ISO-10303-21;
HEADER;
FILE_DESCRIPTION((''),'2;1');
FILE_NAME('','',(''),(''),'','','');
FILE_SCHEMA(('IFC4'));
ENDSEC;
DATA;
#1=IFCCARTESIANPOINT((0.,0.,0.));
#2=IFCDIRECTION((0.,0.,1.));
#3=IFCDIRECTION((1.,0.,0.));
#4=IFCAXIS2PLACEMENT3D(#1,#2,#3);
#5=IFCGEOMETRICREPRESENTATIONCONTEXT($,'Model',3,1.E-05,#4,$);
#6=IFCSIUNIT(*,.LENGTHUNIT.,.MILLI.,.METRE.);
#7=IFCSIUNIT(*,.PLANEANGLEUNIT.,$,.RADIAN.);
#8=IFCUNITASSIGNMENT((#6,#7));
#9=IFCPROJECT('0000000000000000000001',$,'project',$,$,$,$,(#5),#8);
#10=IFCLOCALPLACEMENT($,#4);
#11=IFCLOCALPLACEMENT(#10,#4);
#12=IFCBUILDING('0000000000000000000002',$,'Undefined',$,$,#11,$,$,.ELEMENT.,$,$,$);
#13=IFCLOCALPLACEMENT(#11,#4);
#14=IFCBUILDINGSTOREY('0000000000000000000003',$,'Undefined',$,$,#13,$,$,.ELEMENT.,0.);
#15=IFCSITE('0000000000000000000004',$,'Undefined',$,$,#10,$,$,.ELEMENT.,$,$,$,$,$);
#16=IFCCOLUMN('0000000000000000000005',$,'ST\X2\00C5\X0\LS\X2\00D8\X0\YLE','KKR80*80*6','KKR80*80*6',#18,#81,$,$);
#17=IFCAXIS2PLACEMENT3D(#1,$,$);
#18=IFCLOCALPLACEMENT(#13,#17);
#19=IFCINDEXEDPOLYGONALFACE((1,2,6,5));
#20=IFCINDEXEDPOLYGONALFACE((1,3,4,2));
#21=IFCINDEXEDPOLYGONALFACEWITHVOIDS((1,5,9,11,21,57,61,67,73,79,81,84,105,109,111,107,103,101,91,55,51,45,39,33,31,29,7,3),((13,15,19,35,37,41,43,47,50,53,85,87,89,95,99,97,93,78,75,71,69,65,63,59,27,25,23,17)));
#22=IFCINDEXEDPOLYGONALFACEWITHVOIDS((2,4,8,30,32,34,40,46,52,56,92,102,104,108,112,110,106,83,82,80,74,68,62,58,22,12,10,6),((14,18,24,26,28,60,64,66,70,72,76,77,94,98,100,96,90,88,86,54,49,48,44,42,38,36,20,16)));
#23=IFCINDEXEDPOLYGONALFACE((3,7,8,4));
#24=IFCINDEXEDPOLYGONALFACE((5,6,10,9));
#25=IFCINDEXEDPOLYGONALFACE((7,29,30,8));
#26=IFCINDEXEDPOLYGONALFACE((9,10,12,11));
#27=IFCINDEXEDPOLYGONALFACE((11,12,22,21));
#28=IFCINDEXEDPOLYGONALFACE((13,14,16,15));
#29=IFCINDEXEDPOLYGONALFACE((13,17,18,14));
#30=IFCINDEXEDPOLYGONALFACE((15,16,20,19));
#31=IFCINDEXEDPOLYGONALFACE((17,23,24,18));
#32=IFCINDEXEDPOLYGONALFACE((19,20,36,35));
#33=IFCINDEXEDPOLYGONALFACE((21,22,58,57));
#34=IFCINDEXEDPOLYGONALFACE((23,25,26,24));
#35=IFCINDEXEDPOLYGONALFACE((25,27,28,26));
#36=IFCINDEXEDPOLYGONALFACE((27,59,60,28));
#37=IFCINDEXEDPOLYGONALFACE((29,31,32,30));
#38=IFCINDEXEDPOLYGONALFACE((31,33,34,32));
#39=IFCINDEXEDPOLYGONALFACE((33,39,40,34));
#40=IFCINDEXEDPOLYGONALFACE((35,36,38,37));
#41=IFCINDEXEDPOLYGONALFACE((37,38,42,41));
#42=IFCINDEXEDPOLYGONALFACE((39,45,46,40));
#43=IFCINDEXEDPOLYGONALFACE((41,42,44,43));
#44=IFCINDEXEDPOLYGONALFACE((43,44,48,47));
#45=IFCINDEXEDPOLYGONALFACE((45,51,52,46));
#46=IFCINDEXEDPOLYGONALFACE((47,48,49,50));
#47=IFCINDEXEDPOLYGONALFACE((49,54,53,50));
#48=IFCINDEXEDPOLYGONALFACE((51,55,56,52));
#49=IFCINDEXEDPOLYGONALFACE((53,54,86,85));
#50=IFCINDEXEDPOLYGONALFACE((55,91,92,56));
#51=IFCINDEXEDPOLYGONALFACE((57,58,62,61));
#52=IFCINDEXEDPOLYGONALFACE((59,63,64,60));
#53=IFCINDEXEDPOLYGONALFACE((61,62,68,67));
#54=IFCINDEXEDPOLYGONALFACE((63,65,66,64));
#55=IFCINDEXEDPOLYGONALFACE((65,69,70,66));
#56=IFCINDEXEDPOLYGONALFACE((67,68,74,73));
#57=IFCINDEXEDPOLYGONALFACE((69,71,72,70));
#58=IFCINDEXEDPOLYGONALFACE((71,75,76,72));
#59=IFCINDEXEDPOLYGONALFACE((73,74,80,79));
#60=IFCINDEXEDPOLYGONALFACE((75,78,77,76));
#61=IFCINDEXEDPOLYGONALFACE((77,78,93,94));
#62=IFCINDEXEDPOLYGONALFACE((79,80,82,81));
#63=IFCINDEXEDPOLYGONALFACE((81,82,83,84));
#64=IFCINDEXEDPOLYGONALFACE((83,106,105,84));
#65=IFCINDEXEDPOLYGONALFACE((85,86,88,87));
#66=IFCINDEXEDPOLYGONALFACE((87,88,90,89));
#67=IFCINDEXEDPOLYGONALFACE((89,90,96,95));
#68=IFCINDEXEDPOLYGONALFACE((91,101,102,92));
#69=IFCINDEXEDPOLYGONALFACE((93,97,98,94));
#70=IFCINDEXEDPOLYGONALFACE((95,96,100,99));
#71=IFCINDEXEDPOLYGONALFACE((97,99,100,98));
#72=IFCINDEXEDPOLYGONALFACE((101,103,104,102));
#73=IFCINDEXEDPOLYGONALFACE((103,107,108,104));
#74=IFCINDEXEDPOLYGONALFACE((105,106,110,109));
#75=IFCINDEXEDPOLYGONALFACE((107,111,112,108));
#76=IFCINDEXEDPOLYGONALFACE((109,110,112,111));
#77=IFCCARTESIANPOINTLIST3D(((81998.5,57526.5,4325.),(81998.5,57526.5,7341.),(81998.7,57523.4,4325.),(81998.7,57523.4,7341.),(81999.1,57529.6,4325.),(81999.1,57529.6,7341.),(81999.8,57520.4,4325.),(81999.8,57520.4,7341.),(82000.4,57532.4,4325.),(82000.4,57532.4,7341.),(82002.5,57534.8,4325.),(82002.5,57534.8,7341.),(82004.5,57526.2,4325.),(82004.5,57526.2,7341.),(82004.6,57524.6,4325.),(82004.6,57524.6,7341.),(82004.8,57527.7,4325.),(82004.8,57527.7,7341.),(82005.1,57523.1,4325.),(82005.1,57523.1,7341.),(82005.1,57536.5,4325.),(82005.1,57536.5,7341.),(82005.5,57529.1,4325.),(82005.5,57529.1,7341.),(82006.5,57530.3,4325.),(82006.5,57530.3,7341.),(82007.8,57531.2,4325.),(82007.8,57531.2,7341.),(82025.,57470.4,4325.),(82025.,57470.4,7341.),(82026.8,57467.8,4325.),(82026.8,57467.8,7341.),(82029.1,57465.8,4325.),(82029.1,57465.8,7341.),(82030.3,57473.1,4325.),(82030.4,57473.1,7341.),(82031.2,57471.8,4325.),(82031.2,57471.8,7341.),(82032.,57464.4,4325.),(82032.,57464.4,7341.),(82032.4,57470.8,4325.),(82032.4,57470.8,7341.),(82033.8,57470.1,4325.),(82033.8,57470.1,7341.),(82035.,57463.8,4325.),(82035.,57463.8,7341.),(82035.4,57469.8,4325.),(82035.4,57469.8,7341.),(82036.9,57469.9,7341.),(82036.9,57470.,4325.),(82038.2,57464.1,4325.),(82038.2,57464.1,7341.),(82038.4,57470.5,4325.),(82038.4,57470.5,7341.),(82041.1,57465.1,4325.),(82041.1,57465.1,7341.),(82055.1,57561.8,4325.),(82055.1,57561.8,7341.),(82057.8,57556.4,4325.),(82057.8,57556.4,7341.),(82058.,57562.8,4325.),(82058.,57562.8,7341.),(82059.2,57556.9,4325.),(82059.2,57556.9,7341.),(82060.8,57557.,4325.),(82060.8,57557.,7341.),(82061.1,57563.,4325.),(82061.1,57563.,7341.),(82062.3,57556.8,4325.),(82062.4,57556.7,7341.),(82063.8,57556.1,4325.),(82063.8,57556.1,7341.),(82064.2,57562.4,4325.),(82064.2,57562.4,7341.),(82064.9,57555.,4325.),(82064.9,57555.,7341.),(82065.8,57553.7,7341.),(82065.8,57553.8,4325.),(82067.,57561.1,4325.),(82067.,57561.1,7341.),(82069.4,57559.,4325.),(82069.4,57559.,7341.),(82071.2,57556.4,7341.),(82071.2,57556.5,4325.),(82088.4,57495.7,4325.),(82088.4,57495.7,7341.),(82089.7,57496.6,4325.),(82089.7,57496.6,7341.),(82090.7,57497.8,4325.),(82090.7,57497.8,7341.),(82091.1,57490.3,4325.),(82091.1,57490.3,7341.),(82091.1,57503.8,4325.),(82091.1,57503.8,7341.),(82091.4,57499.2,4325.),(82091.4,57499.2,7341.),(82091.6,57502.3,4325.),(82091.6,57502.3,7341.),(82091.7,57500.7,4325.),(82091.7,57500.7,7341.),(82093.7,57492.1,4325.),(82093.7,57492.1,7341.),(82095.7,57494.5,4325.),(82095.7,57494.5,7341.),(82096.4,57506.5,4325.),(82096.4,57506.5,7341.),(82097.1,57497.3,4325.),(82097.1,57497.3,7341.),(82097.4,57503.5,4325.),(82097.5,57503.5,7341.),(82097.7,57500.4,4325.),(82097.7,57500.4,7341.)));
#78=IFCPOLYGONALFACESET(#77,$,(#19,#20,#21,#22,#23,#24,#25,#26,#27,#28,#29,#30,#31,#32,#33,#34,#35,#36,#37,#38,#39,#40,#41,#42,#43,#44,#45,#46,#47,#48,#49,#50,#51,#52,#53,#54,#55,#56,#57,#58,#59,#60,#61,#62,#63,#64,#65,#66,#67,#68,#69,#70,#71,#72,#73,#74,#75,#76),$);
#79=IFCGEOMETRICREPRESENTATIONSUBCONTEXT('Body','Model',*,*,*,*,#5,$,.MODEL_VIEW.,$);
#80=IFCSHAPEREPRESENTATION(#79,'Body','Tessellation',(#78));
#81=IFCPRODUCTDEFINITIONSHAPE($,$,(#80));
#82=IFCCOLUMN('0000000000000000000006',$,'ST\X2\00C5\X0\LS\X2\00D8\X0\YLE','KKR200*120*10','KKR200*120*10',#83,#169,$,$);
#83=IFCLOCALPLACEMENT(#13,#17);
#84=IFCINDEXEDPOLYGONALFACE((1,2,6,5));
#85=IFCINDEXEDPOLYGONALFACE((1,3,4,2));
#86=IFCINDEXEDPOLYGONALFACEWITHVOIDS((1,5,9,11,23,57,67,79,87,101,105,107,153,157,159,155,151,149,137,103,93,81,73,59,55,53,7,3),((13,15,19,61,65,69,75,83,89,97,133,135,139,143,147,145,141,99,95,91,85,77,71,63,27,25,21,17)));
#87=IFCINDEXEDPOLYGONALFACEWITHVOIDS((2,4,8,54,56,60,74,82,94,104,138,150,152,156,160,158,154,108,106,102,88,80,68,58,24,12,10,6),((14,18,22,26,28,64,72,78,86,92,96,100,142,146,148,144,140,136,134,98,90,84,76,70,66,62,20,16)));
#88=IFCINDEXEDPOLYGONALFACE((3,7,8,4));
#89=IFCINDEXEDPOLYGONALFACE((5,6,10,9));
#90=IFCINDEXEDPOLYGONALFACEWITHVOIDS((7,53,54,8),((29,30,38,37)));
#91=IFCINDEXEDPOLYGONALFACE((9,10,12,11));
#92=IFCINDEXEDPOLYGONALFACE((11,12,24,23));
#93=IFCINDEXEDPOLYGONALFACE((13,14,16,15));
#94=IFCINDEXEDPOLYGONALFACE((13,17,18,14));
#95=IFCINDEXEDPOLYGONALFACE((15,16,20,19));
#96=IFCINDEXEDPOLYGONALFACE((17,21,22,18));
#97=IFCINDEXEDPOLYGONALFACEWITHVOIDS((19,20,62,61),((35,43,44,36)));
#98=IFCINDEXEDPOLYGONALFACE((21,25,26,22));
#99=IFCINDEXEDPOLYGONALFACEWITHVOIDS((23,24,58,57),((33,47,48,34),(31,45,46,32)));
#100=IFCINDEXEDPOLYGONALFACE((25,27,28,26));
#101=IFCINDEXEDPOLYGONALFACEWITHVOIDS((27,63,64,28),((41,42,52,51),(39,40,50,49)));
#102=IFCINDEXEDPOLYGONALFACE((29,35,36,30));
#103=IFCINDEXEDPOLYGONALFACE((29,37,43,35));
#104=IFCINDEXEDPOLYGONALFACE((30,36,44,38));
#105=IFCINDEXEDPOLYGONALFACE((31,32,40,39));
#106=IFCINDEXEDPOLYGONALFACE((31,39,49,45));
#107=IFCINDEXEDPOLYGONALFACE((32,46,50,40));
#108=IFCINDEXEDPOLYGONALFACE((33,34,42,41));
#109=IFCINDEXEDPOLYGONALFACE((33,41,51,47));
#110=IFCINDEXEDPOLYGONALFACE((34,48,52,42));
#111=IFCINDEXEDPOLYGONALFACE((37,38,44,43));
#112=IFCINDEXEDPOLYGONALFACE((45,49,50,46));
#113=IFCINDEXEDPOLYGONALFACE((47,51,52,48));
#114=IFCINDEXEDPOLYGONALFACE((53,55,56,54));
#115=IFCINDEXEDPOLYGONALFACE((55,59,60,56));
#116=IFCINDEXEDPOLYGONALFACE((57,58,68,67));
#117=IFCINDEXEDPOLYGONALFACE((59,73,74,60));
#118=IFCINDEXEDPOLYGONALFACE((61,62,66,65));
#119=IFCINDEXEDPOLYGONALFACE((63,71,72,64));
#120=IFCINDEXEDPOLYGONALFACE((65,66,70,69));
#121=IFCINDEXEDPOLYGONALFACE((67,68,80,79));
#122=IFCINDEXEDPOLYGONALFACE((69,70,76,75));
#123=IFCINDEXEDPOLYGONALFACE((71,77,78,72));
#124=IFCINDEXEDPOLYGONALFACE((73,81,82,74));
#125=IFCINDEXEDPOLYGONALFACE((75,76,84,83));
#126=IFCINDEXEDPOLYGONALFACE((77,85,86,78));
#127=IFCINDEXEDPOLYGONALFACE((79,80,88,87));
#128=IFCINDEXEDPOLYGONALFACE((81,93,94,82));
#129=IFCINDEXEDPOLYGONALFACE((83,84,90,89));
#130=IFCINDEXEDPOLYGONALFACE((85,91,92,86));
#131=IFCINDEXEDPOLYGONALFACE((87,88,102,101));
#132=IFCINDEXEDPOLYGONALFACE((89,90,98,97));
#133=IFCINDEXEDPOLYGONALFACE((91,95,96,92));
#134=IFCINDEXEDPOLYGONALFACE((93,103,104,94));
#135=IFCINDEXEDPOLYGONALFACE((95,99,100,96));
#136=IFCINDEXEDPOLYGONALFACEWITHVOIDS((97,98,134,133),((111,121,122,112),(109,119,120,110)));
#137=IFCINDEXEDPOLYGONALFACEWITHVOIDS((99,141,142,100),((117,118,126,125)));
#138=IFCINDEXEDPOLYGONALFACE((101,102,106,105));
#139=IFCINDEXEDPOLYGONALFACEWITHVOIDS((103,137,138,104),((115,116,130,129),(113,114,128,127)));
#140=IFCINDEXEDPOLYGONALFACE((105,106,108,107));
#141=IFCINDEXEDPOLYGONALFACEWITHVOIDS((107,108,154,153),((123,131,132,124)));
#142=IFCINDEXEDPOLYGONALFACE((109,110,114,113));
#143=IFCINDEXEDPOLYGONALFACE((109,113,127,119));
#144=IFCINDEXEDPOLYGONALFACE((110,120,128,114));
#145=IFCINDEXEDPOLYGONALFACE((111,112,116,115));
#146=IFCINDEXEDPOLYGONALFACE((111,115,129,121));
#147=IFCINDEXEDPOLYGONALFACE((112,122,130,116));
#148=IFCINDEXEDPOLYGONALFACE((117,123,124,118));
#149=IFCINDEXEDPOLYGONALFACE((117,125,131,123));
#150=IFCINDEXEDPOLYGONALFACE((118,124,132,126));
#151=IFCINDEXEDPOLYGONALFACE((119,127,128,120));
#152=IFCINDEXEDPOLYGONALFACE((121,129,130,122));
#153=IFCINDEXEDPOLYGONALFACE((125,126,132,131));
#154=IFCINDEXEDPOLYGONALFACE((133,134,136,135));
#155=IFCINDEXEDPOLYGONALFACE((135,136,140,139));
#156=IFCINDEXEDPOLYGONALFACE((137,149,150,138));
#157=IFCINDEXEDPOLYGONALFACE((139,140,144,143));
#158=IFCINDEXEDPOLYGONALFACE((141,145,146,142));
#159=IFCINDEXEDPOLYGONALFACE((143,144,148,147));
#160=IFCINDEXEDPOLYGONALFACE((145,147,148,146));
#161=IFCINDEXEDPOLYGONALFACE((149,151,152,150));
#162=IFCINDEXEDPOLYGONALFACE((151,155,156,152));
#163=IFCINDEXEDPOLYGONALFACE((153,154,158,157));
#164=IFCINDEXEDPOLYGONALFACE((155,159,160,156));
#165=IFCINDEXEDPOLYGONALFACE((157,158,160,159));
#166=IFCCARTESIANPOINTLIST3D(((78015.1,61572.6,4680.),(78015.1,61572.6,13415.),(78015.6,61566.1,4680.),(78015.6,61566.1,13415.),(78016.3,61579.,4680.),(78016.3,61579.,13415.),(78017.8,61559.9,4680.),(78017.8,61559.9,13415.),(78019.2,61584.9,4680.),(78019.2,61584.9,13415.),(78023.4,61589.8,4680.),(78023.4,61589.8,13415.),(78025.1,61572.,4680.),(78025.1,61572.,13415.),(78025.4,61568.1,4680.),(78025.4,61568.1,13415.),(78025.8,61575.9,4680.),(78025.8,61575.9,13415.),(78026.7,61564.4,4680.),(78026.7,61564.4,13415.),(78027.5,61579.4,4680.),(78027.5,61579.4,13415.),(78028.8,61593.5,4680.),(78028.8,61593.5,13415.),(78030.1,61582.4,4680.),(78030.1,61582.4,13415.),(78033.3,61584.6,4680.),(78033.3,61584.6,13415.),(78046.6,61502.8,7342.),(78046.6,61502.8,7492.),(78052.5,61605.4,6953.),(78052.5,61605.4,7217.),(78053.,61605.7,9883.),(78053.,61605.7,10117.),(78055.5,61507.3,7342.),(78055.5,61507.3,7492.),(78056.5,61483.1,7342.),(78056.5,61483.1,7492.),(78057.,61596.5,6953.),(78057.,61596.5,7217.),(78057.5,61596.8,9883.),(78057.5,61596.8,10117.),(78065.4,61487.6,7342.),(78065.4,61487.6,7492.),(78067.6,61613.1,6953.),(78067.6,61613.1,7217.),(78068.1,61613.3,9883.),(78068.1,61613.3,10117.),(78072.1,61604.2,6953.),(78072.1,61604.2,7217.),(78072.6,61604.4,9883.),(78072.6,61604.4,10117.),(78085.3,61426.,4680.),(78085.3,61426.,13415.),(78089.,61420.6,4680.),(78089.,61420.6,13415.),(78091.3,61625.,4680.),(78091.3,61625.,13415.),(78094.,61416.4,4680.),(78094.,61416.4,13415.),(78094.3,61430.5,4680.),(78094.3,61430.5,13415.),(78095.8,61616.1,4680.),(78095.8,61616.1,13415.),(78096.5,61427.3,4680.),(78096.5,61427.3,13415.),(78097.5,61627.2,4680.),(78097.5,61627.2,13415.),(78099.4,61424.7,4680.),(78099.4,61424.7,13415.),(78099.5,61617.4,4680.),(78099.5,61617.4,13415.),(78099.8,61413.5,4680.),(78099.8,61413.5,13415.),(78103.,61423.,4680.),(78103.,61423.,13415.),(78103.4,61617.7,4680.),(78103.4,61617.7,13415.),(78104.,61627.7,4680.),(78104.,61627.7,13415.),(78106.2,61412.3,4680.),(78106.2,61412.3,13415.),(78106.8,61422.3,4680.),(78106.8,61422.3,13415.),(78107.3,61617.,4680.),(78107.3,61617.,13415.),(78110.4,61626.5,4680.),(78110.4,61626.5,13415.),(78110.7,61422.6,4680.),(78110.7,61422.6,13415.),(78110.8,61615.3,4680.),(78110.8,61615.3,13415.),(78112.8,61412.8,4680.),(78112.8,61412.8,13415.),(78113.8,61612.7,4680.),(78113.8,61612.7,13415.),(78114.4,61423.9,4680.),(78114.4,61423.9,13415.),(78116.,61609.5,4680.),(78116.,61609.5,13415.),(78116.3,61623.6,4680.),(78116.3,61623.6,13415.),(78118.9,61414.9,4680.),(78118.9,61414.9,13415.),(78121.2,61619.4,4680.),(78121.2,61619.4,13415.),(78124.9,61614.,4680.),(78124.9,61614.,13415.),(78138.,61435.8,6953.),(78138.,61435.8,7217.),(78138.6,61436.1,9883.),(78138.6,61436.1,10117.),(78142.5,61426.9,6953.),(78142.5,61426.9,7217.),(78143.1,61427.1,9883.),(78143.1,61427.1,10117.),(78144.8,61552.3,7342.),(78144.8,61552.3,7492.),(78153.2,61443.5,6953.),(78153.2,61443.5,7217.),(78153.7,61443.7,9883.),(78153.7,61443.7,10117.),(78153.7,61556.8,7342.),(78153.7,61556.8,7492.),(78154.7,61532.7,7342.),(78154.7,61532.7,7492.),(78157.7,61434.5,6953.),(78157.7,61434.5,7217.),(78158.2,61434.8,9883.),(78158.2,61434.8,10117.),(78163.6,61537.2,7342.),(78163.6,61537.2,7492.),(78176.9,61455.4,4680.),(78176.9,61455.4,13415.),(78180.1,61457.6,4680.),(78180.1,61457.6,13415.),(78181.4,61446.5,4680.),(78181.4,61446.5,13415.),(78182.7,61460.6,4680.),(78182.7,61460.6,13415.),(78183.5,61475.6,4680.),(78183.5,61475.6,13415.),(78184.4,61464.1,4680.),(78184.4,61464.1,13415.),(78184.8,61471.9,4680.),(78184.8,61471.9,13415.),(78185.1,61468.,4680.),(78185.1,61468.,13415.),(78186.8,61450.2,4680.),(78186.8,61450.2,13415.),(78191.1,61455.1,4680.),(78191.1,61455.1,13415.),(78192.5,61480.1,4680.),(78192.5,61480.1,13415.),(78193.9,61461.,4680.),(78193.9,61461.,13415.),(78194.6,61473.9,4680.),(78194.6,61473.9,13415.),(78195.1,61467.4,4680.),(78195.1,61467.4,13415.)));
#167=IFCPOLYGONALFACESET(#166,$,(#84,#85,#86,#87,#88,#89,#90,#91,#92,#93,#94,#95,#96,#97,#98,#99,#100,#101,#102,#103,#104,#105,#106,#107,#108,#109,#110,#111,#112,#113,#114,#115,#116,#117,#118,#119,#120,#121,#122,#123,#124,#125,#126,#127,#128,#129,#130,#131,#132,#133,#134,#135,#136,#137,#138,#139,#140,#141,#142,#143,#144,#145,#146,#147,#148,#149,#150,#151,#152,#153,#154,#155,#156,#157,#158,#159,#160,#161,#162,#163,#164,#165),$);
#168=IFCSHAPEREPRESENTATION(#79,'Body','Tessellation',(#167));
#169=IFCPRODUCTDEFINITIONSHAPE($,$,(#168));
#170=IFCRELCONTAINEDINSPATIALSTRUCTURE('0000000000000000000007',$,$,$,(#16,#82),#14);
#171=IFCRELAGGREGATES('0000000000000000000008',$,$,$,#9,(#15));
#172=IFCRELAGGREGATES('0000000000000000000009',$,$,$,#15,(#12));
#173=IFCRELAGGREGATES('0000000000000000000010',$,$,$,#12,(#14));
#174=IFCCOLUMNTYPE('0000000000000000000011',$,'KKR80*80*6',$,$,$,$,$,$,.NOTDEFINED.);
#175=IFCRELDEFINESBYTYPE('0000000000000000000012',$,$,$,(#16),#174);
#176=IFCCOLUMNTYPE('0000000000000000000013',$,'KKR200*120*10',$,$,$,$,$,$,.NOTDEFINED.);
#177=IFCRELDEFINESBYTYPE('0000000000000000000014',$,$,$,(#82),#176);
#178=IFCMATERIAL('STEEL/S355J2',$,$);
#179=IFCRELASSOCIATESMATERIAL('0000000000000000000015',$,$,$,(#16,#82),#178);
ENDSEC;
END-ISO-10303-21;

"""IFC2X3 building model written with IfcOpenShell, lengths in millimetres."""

from ifc_helpers import new_model, si_unit, frame, origin_with_axes, origin_2d_with_axis, place, context, subcontext, project, spatial, polyline, hollow_rectangle, outline, extrude, boolean, clip, halfspace, material, type_object, element, save


model = new_model("IFC2X3")

# Units and contexts
model_context = context("Model", 3, precision=1e-05, world=origin_with_axes())
body_context = subcontext(model_context, "Body", "Model", "MODEL_VIEW")
ifc_project = project(units=[si_unit("LENGTHUNIT", "METRE", prefix="MILLI"), si_unit("PLANEANGLEUNIT", "RADIAN")], contexts=[model_context])

# Site, building, storey
site_placement = place(None, origin_with_axes())
site = spatial("IfcSite", under=ifc_project, at=site_placement, Name="Undefined", CompositionType="ELEMENT")
building_placement = place(site_placement, origin_with_axes())
building = spatial("IfcBuilding", under=site, at=building_placement, Name="Undefined", CompositionType="ELEMENT")
storey_placement = place(building_placement, origin_with_axes())
storey = spatial("IfcBuildingStorey", under=building, at=storey_placement, Name="Undefined", CompositionType="ELEMENT", Elevation=0.0)

# Columns
ifc_material_1 = material(Name="STEEL/S355J2")
column_type_1 = type_object("IfcColumnType", Name="KKR80*80*6", PredefinedType="NOTDEFINED")
column_1_placement = place(storey_placement, frame((82048.1, 57513.4, 4325.0), z_axis=(0.000001, -0.000003, 1.0), x_axis=(-0.450512, 0.89277, 0.000003)))
element("IfcColumn", 1, at=column_1_placement, inside=storey, type_object=column_type_1, material=ifc_material_1, Name="STÅLSØYLE", Description="KKR80*80*6", ObjectType="KKR80*80*6", context=body_context, shape_type="Clipping", body=[
    clip(extrude(hollow_rectangle(XDim=80.0, YDim=80.0, WallThickness=6.0, InnerFilletRadius=6.0, OuterFilletRadius=12.0, at=origin_2d_with_axis()), frame((0.0, 0.0, 3016.0), z_axis=(0.0, 0.0, -1.0), x_axis=(0.0, 1.0, 0.0)), (0.0, 0.0, 1.0), 3016.0), halfspace(frame((-40.0, 0.0, 3016.0), z_axis=(-0.000003, 0.0, -1.0), x_axis=(0.0, -1.0, 0.0)), True)),
])
column_type_2 = type_object("IfcColumnType", Name="KKR200*120*10", PredefinedType="NOTDEFINED")
column_2_placement = place(storey_placement, frame((78105.1, 61520.0, 4680.0), z_axis=(0.0, 0.0, 1.0), x_axis=(-0.450512, 0.89277, 0.0)))
element("IfcColumn", 2, at=column_2_placement, inside=storey, type_object=column_type_2, material=ifc_material_1, Name="STÅLSØYLE", Description="KKR200*120*10", ObjectType="KKR200*120*10", context=body_context, shape_type="CSG", body=[
    boolean("DIFFERENCE", boolean("DIFFERENCE", boolean("DIFFERENCE", boolean("DIFFERENCE", boolean("DIFFERENCE", boolean("DIFFERENCE", extrude(hollow_rectangle(XDim=120.0, YDim=200.0, WallThickness=10.0, InnerFilletRadius=15.0, OuterFilletRadius=25.0, at=origin_2d_with_axis()), frame((0.0, 0.0, 8735.0), z_axis=(0.0, 0.0, -1.0), x_axis=(0.0, 1.0, 0.0)), (0.0, 0.0, 1.0), 8735.0), extrude(outline(polyline([(0.0, 0.0), (248.0, 0.0), (248.0, 150.0), (0.0, 150.0), (0.0, 0.0)])), frame((-11.0, 70.0, 2812.0), z_axis=(1.0, -0.000155, 0.0), x_axis=(-0.000155, -1.0, 0.0)), (0.0, 0.0, 1.0), 22.0)), extrude(outline(polyline([(0.0, 0.0), (17.0, 0.0), (17.0, 264.0), (0.0, 264.0), (0.0, 0.0)])), frame((-80.0, -8.5, 2537.0), z_axis=(-1.0, 0.000114, 0.0), x_axis=(0.000114, 1.0, 0.0)), (0.0, 0.0, 1.0), 30.0)), extrude(outline(polyline([(0.0, 0.0), (17.0, 0.0), (17.0, 264.0), (0.0, 264.0), (0.0, 0.0)])), frame((110.0, -8.5, 2537.0), z_axis=(-1.0, 0.000114, 0.0), x_axis=(0.000114, 1.0, 0.0)), (0.0, 0.0, 1.0), 30.0)), extrude(outline(polyline([(0.0, 0.0), (17.0, 0.0), (17.0, 234.0), (0.0, 234.0), (0.0, 0.0)])), frame((-80.0, -9.0, 5437.0), z_axis=(-1.0, -0.000005, 0.0), x_axis=(-0.000005, 1.0, 0.0)), (0.0, 0.0, 1.0), 30.0)), extrude(outline(polyline([(0.0, 0.0), (17.0, 0.0), (17.0, 234.0), (0.0, 234.0), (0.0, 0.0)])), frame((110.0, -9.0, 5437.0), z_axis=(-1.0, -0.000005, 0.0), x_axis=(-0.000005, 1.0, 0.0)), (0.0, 0.0, 1.0), 30.0)), halfspace(frame((-100.0, 0.0, 8735.0), z_axis=(0.0, 0.0, -1.0), x_axis=(0.0, -1.0, 0.0)), True)),
])

save(model, "model.ifc")
